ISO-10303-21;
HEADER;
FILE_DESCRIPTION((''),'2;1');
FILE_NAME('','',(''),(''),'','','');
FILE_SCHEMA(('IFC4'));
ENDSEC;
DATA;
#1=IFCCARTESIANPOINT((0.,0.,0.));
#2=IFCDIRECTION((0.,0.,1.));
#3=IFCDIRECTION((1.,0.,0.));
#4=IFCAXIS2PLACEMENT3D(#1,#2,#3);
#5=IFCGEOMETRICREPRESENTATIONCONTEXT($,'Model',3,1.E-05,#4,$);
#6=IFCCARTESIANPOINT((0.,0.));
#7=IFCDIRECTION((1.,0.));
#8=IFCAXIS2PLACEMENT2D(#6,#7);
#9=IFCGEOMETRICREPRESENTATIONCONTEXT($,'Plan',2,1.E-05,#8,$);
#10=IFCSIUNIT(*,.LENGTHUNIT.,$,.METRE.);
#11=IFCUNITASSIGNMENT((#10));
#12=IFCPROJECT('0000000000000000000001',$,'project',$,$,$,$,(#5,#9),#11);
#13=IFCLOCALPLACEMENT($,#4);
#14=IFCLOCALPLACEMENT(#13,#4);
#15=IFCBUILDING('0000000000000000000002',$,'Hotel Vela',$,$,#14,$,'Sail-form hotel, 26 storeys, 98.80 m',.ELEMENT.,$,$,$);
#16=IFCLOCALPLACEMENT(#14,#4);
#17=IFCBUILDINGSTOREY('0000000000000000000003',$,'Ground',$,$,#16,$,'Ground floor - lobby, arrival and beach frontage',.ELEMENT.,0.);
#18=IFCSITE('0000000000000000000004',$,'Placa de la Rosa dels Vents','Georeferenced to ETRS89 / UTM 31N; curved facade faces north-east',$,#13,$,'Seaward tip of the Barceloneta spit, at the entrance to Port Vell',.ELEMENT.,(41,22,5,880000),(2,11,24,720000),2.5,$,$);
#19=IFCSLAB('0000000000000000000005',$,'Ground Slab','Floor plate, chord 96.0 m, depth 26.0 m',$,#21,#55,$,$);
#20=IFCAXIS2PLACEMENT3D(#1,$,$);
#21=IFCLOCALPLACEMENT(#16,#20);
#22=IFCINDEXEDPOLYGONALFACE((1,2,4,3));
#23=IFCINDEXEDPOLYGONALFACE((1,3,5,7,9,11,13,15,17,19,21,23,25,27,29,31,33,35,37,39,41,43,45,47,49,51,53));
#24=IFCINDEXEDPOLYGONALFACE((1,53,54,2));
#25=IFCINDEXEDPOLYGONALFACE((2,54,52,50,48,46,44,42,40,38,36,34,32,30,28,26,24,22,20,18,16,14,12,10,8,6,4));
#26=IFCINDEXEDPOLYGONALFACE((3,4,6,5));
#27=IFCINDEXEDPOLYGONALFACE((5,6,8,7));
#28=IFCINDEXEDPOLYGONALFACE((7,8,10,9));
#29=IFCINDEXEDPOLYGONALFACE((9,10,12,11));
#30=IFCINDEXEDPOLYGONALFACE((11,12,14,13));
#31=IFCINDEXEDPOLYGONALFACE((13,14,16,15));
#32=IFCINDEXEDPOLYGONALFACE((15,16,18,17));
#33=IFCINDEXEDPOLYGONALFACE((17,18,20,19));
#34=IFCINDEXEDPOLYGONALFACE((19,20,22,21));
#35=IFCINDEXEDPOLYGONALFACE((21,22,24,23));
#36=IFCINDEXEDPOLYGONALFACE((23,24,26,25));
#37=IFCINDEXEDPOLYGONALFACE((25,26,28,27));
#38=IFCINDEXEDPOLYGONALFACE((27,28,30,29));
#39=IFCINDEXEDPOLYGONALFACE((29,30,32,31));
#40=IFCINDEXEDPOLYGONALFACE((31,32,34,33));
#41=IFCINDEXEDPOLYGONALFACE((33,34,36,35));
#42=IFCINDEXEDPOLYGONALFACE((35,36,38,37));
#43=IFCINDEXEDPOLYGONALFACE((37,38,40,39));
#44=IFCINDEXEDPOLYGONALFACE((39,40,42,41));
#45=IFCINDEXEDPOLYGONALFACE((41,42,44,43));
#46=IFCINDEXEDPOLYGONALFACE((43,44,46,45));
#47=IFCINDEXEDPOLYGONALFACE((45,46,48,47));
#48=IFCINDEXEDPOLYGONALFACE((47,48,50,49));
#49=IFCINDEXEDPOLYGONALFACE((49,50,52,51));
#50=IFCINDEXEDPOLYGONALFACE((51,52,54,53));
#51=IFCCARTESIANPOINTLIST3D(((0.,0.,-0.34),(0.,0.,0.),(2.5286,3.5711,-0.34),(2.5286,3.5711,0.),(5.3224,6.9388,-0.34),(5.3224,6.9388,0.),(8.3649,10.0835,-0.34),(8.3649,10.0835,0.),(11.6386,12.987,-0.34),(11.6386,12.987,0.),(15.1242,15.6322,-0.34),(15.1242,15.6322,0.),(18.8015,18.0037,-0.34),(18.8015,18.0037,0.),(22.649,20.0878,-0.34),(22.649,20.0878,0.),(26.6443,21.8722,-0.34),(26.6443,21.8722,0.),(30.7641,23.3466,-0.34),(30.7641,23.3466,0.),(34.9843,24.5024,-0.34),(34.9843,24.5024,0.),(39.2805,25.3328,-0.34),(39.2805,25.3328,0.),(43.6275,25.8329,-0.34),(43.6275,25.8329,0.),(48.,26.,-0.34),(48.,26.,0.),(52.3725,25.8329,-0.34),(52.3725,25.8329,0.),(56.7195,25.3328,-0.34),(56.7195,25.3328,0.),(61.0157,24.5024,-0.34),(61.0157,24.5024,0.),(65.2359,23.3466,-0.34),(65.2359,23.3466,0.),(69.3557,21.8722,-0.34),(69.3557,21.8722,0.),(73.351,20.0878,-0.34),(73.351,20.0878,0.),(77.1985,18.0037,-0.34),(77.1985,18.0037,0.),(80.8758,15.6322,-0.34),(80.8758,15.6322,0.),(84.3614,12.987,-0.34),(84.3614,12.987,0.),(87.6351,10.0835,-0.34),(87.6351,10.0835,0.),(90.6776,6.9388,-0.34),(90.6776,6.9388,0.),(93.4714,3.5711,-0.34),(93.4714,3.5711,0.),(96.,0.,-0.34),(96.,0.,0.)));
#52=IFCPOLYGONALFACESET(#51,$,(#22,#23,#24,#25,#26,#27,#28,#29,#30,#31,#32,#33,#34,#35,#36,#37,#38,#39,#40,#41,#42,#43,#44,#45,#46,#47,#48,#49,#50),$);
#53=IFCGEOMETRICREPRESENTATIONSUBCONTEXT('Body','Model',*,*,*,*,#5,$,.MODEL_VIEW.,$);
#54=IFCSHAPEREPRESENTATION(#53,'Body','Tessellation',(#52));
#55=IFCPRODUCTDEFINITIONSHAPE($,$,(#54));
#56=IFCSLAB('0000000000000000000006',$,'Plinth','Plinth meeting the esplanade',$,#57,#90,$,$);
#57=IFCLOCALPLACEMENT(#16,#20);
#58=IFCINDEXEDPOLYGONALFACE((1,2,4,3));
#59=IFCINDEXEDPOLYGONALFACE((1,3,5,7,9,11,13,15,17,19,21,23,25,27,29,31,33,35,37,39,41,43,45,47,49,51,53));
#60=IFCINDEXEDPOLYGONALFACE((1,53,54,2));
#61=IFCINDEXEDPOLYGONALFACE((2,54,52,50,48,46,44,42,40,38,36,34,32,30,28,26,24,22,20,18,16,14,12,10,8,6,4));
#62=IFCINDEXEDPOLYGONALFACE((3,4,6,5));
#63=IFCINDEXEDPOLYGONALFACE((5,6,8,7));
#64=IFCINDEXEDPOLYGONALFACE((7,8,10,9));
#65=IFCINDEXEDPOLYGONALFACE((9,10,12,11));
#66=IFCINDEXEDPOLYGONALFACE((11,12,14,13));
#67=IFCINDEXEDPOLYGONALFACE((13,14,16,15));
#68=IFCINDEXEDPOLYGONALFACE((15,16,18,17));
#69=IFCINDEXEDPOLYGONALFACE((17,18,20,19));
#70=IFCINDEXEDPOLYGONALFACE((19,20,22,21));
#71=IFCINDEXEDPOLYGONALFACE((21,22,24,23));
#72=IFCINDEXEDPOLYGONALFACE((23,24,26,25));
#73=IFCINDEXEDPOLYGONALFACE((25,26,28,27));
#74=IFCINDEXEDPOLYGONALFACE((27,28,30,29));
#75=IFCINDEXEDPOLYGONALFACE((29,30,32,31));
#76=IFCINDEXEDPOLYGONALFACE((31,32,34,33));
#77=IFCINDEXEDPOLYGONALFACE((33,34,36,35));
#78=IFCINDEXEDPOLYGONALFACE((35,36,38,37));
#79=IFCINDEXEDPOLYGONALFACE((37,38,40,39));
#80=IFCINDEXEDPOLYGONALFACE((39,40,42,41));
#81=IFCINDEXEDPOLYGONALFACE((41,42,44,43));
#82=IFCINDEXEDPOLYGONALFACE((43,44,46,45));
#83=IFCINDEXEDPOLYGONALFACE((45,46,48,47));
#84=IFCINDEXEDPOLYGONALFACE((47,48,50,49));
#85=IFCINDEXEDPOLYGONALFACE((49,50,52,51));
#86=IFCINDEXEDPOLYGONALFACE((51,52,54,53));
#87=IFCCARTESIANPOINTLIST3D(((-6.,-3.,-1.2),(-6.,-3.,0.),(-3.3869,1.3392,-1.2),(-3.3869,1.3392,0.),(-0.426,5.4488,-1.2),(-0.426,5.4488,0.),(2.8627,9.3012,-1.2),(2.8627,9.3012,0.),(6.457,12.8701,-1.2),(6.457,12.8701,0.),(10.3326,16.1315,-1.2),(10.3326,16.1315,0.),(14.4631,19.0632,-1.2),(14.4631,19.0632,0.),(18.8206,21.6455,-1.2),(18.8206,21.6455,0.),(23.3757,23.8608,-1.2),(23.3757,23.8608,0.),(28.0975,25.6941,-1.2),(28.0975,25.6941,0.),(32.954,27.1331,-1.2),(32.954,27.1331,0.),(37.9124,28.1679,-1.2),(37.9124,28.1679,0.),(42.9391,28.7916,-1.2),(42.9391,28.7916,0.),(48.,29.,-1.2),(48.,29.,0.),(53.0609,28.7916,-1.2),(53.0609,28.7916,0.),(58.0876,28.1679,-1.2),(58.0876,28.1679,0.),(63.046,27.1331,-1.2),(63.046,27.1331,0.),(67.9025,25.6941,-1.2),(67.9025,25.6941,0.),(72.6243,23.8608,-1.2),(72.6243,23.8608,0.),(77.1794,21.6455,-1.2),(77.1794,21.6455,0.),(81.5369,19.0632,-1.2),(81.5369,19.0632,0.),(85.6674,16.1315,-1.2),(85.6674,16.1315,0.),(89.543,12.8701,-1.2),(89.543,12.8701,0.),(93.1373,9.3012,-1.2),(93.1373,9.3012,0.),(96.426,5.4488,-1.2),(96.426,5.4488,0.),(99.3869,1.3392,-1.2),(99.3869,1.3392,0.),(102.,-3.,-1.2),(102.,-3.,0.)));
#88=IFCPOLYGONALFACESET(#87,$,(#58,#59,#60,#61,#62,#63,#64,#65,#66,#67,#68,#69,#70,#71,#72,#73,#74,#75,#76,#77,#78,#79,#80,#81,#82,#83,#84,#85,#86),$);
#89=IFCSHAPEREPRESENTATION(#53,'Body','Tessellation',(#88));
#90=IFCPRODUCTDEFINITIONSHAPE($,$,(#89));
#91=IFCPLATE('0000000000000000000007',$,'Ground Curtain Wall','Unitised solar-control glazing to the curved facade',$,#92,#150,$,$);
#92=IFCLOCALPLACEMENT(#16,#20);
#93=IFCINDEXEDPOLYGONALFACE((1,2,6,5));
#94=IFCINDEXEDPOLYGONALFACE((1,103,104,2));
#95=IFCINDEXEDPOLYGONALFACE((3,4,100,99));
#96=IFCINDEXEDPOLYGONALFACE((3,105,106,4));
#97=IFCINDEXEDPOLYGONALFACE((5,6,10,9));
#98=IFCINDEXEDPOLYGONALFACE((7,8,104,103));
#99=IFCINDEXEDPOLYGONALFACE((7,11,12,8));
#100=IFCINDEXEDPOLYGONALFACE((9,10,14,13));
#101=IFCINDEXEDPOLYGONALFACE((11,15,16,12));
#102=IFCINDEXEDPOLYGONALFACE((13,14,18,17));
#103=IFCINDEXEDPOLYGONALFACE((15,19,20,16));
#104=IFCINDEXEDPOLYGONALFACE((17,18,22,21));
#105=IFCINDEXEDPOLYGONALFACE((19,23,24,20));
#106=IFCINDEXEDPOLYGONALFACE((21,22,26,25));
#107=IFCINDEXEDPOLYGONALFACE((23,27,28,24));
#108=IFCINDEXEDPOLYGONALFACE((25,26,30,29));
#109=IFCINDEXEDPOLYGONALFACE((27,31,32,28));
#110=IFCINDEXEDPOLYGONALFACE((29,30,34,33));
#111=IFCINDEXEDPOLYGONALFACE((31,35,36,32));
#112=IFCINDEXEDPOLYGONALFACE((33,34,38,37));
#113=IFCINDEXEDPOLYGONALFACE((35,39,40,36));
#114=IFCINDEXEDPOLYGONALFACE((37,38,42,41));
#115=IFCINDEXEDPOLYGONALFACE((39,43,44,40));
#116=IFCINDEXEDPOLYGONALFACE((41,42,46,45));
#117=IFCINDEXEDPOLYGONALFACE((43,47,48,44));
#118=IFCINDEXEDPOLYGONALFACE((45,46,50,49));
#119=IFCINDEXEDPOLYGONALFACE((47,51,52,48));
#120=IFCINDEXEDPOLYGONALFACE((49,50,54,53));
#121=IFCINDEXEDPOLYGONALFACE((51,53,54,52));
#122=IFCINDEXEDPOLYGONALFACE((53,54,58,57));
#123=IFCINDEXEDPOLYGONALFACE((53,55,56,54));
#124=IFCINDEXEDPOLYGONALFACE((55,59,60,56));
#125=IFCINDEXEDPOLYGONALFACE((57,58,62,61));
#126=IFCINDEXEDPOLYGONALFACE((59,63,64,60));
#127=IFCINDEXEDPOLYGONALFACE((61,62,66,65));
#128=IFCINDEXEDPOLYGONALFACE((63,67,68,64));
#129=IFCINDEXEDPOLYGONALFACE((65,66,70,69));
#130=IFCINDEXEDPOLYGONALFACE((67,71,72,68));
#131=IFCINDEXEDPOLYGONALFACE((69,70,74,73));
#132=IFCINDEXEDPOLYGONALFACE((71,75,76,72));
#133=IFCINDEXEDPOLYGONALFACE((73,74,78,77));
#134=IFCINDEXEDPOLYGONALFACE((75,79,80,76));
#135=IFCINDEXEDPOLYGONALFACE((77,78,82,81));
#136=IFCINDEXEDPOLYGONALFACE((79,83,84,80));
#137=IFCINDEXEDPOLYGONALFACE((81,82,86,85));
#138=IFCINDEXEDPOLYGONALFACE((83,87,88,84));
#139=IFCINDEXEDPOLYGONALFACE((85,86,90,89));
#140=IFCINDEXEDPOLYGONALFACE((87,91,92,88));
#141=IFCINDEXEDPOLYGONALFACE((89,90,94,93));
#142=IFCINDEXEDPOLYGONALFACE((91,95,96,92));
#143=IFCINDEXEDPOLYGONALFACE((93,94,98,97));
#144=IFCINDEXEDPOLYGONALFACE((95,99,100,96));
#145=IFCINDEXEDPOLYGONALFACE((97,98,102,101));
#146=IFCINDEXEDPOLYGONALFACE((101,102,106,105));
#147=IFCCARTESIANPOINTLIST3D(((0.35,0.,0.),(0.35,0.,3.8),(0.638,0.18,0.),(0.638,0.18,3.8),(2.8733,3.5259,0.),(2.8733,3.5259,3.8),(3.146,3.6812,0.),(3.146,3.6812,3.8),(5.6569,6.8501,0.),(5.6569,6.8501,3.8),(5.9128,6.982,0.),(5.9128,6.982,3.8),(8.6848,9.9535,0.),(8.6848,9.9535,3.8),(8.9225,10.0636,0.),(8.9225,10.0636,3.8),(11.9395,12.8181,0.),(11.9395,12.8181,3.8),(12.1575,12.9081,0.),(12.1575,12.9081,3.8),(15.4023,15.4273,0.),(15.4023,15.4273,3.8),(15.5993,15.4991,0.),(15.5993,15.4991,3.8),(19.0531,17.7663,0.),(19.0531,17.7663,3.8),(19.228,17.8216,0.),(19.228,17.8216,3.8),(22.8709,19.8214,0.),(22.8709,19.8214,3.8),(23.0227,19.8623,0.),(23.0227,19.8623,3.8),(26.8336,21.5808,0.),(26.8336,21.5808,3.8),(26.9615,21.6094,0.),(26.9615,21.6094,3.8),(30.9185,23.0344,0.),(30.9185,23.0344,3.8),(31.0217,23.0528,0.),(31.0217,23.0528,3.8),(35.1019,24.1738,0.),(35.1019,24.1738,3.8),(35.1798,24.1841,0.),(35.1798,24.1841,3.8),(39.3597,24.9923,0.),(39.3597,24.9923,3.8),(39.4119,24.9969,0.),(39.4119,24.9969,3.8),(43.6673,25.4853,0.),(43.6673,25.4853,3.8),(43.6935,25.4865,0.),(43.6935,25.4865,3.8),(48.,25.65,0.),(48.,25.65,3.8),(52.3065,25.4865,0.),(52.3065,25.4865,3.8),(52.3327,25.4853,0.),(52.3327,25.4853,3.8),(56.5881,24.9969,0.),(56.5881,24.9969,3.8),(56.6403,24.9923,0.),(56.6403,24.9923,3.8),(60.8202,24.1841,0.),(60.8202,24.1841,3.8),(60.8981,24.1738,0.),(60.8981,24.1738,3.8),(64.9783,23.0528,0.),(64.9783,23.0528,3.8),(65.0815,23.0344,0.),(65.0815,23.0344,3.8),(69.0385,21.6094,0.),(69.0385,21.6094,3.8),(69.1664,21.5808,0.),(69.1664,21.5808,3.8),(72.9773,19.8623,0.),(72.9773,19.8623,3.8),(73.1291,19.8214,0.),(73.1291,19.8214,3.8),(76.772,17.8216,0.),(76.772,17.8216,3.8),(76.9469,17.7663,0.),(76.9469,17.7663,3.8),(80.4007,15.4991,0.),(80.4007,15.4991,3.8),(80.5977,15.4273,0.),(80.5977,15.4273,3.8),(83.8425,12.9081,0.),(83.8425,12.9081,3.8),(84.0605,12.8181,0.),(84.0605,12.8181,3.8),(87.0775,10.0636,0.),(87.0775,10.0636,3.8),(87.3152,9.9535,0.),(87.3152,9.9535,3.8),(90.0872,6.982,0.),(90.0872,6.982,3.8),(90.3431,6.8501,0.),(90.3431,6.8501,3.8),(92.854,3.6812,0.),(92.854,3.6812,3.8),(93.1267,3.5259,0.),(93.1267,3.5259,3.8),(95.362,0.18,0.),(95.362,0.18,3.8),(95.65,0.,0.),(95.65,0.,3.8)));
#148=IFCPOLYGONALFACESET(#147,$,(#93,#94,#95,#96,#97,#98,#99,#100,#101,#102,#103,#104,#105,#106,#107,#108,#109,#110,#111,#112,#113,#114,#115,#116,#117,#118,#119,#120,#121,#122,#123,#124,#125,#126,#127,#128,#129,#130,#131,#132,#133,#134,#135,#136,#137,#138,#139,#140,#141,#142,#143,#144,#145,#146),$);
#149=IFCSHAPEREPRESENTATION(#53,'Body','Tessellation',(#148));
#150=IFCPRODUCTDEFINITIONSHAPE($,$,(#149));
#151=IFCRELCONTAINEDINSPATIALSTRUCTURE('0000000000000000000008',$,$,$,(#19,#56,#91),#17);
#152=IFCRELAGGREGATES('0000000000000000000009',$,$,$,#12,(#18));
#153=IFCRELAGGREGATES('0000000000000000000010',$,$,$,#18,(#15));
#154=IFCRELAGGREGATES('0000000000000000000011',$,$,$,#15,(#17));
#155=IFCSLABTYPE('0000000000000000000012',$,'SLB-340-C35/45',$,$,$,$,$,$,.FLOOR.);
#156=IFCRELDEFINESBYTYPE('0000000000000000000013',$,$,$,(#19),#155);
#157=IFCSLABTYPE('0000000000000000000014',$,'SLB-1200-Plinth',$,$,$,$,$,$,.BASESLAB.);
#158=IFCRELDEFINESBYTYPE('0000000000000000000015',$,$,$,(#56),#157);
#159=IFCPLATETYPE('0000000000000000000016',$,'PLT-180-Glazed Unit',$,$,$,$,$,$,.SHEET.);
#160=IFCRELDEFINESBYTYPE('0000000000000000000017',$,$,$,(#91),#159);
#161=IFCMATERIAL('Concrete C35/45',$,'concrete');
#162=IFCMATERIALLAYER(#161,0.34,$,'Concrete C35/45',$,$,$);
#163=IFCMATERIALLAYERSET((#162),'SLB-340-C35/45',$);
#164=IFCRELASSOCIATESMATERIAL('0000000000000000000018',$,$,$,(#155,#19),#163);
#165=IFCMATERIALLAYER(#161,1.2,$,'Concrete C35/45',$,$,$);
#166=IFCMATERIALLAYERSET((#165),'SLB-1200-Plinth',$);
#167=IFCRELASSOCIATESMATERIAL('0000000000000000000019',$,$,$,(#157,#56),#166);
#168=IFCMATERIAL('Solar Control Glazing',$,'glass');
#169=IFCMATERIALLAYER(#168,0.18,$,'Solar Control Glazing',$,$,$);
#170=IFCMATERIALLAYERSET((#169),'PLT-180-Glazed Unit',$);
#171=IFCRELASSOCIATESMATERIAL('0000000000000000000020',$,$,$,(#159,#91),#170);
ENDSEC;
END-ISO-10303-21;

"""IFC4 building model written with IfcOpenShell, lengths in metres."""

from ifc_helpers import new_model, si_unit, frame, origin_with_axes, origin_2d_with_axis, place, context, subcontext, project, spatial, line, indexed_curve, outline, extrude, material, layer, layer_set, layer_usage, type_object, element, save


model = new_model("IFC4")

# Units and contexts
model_context = context("Model", 3, precision=1e-05, world=origin_with_axes())
plan_context = context("Plan", 2, precision=1e-05, world=origin_2d_with_axis())
body_context = subcontext(model_context, "Body", "Model", "MODEL_VIEW")
ifc_project = project(units=[si_unit("LENGTHUNIT", "METRE")], contexts=[model_context, plan_context])

# Site, building, storey
site_placement = place(None, origin_with_axes())
site = spatial("IfcSite", under=ifc_project, at=site_placement, Name="Placa de la Rosa dels Vents", Description="Georeferenced to ETRS89 / UTM 31N; curved facade faces north-east", LongName="Seaward tip of the Barceloneta spit, at the entrance to Port Vell", CompositionType="ELEMENT", RefLatitude=(41, 22, 5, 880000), RefLongitude=(2, 11, 24, 720000), RefElevation=2.5)
building_placement = place(site_placement, origin_with_axes())
building = spatial("IfcBuilding", under=site, at=building_placement, Name="Hotel Vela", LongName="Sail-form hotel, 26 storeys, 98.80 m", CompositionType="ELEMENT")
storey_placement = place(building_placement, origin_with_axes())
storey = spatial("IfcBuildingStorey", under=building, at=storey_placement, Name="Ground", LongName="Ground floor - lobby, arrival and beach frontage", CompositionType="ELEMENT", Elevation=0.0)

# Slabs
ifc_material_1 = material(Name="Concrete C35/45", Category="concrete")
ifc_layer_1 = layer(ifc_material_1, 0.34, Name="Concrete C35/45")
ifc_layer_set_1 = layer_set([ifc_layer_1], Name="SLB-340-C35/45")
ifc_layer_usage_1 = layer_usage(ifc_layer_set_1, "AXIS3", "POSITIVE", 0.0)
slab_type_1 = type_object("IfcSlabType", Name="SLB-340-C35/45", PredefinedType="FLOOR", material=ifc_layer_set_1)
slab_1_placement = place(storey_placement, frame((0.0, 0.0, -0.34), z_axis=(0.0, 0.0, 1.0), x_axis=(1.0, 0.0, 0.0)))
element("IfcSlab", 1, at=slab_1_placement, inside=storey, type_object=slab_type_1, material=ifc_layer_usage_1, Name="Ground Slab", Description="Floor plate, chord 96.0 m, depth 26.0 m", context=body_context, shape_type="SweptSolid", body=[
    extrude(outline(indexed_curve([(0.0, 0.0), (96.0, 0.0), (93.4714, 3.5711), (90.6776, 6.9388), (87.6351, 10.0835), (84.3614, 12.987), (80.8758, 15.6322), (77.1985, 18.0037), (73.351, 20.0878), (69.3557, 21.8722), (65.2359, 23.3466), (61.0157, 24.5024), (56.7195, 25.3328), (52.3725, 25.8329), (48.0, 26.0), (43.6275, 25.8329), (39.2805, 25.3328), (34.9843, 24.5024), (30.7641, 23.3466), (26.6443, 21.8722), (22.649, 20.0878), (18.8015, 18.0037), (15.1242, 15.6322), (11.6386, 12.987), (8.3649, 10.0835), (5.3224, 6.9388), (2.5286, 3.5711)], segments=[line(1, 2, 3, 4, 5, 6, 7, 8, 9, 10, 11, 12, 13, 14, 15, 16, 17, 18, 19, 20, 21, 22, 23, 24, 25, 26, 27, 1)])), origin_with_axes(), (0.0, 0.0, 1.0), 0.34),
])
ifc_layer_2 = layer(ifc_material_1, 1.2, Name="Concrete C35/45")
ifc_layer_set_2 = layer_set([ifc_layer_2], Name="SLB-1200-Plinth")
ifc_layer_usage_2 = layer_usage(ifc_layer_set_2, "AXIS3", "POSITIVE", 0.0)
slab_type_2 = type_object("IfcSlabType", Name="SLB-1200-Plinth", PredefinedType="BASESLAB", material=ifc_layer_set_2)
slab_2_placement = place(storey_placement, frame((-6.0, -3.0, -1.2), z_axis=(0.0, 0.0, 1.0), x_axis=(1.0, 0.0, 0.0)))
element("IfcSlab", 2, at=slab_2_placement, inside=storey, type_object=slab_type_2, material=ifc_layer_usage_2, Name="Plinth", Description="Plinth meeting the esplanade", context=body_context, shape_type="SweptSolid", body=[
    extrude(outline(indexed_curve([(0.0, 0.0), (108.0, 0.0), (105.3869, 4.3392), (102.426, 8.4488), (99.1373, 12.3012), (95.543, 15.8701), (91.6674, 19.1315), (87.5369, 22.0632), (83.1794, 24.6455), (78.6243, 26.8608), (73.9025, 28.6941), (69.046, 30.1331), (64.0876, 31.1679), (59.0609, 31.7916), (54.0, 32.0), (48.9391, 31.7916), (43.9124, 31.1679), (38.954, 30.1331), (34.0975, 28.6941), (29.3757, 26.8608), (24.8206, 24.6455), (20.4631, 22.0632), (16.3326, 19.1315), (12.457, 15.8701), (8.8627, 12.3012), (5.574, 8.4488), (2.6131, 4.3392)], segments=[line(1, 2, 3, 4, 5, 6, 7, 8, 9, 10, 11, 12, 13, 14, 15, 16, 17, 18, 19, 20, 21, 22, 23, 24, 25, 26, 27, 1)])), origin_with_axes(), (0.0, 0.0, 1.0), 1.2),
])

# Plate
ifc_material_2 = material(Name="Solar Control Glazing", Category="glass")
ifc_layer_3 = layer(ifc_material_2, 0.18, Name="Solar Control Glazing")
ifc_layer_set_3 = layer_set([ifc_layer_3], Name="PLT-180-Glazed Unit")
ifc_layer_usage_3 = layer_usage(ifc_layer_set_3, "AXIS2", "POSITIVE", 0.0)
plate_type_1 = type_object("IfcPlateType", Name="PLT-180-Glazed Unit", PredefinedType="SHEET", material=ifc_layer_set_3)
plate_1_placement = place(storey_placement, frame((0.35, 0.0, 0.0), z_axis=(0.0, 0.0, 1.0), x_axis=(1.0, 0.0, 0.0)))
element("IfcPlate", 3, at=plate_1_placement, inside=storey, type_object=plate_type_1, material=ifc_layer_usage_3, Name="Ground Curtain Wall", Description="Unitised solar-control glazing to the curved facade", context=body_context, shape_type="SweptSolid", body=[
    extrude(outline(indexed_curve([(95.3, 0.0), (92.7767, 3.5259), (89.9931, 6.8501), (86.9652, 9.9535), (83.7105, 12.8181), (80.2477, 15.4273), (76.5969, 17.7663), (72.7791, 19.8214), (68.8164, 21.5808), (64.7315, 23.0344), (60.5481, 24.1738), (56.2903, 24.9923), (51.9827, 25.4853), (47.65, 25.65), (43.3173, 25.4853), (39.0097, 24.9923), (34.7519, 24.1738), (30.5685, 23.0344), (26.4836, 21.5808), (22.5209, 19.8214), (18.7031, 17.7663), (15.0523, 15.4273), (11.5895, 12.8181), (8.3348, 9.9535), (5.3069, 6.8501), (2.5233, 3.5259), (0.0, 0.0), (95.012, 0.18), (2.796, 3.6812), (5.5628, 6.982), (8.5725, 10.0636), (11.8075, 12.9081), (15.2493, 15.4991), (18.878, 17.8216), (22.6727, 19.8623), (26.6115, 21.6094), (30.6717, 23.0528), (34.8298, 24.1841), (39.0619, 24.9969), (43.3435, 25.4865), (47.65, 25.65), (51.9565, 25.4865), (56.2381, 24.9969), (60.4702, 24.1841), (64.6283, 23.0528), (68.6885, 21.6094), (72.6273, 19.8623), (76.422, 17.8216), (80.0507, 15.4991), (83.4925, 12.9081), (86.7275, 10.0636), (89.7372, 6.982), (92.504, 3.6812), (0.288, 0.18)], segments=[line(1, 2, 3, 4, 5, 6, 7, 8, 9, 10, 11, 12, 13, 14, 15, 16, 17, 18, 19, 20, 21, 22, 23, 24, 25, 26, 27, 28, 29, 30, 31, 32, 33, 34, 35, 36, 37, 38, 39, 40, 41, 42, 43, 44, 45, 46, 47, 48, 49, 50, 51, 52, 53, 54, 1)])), origin_with_axes(), (0.0, 0.0, 1.0), 3.8),
])

save(model, "model.ifc")
